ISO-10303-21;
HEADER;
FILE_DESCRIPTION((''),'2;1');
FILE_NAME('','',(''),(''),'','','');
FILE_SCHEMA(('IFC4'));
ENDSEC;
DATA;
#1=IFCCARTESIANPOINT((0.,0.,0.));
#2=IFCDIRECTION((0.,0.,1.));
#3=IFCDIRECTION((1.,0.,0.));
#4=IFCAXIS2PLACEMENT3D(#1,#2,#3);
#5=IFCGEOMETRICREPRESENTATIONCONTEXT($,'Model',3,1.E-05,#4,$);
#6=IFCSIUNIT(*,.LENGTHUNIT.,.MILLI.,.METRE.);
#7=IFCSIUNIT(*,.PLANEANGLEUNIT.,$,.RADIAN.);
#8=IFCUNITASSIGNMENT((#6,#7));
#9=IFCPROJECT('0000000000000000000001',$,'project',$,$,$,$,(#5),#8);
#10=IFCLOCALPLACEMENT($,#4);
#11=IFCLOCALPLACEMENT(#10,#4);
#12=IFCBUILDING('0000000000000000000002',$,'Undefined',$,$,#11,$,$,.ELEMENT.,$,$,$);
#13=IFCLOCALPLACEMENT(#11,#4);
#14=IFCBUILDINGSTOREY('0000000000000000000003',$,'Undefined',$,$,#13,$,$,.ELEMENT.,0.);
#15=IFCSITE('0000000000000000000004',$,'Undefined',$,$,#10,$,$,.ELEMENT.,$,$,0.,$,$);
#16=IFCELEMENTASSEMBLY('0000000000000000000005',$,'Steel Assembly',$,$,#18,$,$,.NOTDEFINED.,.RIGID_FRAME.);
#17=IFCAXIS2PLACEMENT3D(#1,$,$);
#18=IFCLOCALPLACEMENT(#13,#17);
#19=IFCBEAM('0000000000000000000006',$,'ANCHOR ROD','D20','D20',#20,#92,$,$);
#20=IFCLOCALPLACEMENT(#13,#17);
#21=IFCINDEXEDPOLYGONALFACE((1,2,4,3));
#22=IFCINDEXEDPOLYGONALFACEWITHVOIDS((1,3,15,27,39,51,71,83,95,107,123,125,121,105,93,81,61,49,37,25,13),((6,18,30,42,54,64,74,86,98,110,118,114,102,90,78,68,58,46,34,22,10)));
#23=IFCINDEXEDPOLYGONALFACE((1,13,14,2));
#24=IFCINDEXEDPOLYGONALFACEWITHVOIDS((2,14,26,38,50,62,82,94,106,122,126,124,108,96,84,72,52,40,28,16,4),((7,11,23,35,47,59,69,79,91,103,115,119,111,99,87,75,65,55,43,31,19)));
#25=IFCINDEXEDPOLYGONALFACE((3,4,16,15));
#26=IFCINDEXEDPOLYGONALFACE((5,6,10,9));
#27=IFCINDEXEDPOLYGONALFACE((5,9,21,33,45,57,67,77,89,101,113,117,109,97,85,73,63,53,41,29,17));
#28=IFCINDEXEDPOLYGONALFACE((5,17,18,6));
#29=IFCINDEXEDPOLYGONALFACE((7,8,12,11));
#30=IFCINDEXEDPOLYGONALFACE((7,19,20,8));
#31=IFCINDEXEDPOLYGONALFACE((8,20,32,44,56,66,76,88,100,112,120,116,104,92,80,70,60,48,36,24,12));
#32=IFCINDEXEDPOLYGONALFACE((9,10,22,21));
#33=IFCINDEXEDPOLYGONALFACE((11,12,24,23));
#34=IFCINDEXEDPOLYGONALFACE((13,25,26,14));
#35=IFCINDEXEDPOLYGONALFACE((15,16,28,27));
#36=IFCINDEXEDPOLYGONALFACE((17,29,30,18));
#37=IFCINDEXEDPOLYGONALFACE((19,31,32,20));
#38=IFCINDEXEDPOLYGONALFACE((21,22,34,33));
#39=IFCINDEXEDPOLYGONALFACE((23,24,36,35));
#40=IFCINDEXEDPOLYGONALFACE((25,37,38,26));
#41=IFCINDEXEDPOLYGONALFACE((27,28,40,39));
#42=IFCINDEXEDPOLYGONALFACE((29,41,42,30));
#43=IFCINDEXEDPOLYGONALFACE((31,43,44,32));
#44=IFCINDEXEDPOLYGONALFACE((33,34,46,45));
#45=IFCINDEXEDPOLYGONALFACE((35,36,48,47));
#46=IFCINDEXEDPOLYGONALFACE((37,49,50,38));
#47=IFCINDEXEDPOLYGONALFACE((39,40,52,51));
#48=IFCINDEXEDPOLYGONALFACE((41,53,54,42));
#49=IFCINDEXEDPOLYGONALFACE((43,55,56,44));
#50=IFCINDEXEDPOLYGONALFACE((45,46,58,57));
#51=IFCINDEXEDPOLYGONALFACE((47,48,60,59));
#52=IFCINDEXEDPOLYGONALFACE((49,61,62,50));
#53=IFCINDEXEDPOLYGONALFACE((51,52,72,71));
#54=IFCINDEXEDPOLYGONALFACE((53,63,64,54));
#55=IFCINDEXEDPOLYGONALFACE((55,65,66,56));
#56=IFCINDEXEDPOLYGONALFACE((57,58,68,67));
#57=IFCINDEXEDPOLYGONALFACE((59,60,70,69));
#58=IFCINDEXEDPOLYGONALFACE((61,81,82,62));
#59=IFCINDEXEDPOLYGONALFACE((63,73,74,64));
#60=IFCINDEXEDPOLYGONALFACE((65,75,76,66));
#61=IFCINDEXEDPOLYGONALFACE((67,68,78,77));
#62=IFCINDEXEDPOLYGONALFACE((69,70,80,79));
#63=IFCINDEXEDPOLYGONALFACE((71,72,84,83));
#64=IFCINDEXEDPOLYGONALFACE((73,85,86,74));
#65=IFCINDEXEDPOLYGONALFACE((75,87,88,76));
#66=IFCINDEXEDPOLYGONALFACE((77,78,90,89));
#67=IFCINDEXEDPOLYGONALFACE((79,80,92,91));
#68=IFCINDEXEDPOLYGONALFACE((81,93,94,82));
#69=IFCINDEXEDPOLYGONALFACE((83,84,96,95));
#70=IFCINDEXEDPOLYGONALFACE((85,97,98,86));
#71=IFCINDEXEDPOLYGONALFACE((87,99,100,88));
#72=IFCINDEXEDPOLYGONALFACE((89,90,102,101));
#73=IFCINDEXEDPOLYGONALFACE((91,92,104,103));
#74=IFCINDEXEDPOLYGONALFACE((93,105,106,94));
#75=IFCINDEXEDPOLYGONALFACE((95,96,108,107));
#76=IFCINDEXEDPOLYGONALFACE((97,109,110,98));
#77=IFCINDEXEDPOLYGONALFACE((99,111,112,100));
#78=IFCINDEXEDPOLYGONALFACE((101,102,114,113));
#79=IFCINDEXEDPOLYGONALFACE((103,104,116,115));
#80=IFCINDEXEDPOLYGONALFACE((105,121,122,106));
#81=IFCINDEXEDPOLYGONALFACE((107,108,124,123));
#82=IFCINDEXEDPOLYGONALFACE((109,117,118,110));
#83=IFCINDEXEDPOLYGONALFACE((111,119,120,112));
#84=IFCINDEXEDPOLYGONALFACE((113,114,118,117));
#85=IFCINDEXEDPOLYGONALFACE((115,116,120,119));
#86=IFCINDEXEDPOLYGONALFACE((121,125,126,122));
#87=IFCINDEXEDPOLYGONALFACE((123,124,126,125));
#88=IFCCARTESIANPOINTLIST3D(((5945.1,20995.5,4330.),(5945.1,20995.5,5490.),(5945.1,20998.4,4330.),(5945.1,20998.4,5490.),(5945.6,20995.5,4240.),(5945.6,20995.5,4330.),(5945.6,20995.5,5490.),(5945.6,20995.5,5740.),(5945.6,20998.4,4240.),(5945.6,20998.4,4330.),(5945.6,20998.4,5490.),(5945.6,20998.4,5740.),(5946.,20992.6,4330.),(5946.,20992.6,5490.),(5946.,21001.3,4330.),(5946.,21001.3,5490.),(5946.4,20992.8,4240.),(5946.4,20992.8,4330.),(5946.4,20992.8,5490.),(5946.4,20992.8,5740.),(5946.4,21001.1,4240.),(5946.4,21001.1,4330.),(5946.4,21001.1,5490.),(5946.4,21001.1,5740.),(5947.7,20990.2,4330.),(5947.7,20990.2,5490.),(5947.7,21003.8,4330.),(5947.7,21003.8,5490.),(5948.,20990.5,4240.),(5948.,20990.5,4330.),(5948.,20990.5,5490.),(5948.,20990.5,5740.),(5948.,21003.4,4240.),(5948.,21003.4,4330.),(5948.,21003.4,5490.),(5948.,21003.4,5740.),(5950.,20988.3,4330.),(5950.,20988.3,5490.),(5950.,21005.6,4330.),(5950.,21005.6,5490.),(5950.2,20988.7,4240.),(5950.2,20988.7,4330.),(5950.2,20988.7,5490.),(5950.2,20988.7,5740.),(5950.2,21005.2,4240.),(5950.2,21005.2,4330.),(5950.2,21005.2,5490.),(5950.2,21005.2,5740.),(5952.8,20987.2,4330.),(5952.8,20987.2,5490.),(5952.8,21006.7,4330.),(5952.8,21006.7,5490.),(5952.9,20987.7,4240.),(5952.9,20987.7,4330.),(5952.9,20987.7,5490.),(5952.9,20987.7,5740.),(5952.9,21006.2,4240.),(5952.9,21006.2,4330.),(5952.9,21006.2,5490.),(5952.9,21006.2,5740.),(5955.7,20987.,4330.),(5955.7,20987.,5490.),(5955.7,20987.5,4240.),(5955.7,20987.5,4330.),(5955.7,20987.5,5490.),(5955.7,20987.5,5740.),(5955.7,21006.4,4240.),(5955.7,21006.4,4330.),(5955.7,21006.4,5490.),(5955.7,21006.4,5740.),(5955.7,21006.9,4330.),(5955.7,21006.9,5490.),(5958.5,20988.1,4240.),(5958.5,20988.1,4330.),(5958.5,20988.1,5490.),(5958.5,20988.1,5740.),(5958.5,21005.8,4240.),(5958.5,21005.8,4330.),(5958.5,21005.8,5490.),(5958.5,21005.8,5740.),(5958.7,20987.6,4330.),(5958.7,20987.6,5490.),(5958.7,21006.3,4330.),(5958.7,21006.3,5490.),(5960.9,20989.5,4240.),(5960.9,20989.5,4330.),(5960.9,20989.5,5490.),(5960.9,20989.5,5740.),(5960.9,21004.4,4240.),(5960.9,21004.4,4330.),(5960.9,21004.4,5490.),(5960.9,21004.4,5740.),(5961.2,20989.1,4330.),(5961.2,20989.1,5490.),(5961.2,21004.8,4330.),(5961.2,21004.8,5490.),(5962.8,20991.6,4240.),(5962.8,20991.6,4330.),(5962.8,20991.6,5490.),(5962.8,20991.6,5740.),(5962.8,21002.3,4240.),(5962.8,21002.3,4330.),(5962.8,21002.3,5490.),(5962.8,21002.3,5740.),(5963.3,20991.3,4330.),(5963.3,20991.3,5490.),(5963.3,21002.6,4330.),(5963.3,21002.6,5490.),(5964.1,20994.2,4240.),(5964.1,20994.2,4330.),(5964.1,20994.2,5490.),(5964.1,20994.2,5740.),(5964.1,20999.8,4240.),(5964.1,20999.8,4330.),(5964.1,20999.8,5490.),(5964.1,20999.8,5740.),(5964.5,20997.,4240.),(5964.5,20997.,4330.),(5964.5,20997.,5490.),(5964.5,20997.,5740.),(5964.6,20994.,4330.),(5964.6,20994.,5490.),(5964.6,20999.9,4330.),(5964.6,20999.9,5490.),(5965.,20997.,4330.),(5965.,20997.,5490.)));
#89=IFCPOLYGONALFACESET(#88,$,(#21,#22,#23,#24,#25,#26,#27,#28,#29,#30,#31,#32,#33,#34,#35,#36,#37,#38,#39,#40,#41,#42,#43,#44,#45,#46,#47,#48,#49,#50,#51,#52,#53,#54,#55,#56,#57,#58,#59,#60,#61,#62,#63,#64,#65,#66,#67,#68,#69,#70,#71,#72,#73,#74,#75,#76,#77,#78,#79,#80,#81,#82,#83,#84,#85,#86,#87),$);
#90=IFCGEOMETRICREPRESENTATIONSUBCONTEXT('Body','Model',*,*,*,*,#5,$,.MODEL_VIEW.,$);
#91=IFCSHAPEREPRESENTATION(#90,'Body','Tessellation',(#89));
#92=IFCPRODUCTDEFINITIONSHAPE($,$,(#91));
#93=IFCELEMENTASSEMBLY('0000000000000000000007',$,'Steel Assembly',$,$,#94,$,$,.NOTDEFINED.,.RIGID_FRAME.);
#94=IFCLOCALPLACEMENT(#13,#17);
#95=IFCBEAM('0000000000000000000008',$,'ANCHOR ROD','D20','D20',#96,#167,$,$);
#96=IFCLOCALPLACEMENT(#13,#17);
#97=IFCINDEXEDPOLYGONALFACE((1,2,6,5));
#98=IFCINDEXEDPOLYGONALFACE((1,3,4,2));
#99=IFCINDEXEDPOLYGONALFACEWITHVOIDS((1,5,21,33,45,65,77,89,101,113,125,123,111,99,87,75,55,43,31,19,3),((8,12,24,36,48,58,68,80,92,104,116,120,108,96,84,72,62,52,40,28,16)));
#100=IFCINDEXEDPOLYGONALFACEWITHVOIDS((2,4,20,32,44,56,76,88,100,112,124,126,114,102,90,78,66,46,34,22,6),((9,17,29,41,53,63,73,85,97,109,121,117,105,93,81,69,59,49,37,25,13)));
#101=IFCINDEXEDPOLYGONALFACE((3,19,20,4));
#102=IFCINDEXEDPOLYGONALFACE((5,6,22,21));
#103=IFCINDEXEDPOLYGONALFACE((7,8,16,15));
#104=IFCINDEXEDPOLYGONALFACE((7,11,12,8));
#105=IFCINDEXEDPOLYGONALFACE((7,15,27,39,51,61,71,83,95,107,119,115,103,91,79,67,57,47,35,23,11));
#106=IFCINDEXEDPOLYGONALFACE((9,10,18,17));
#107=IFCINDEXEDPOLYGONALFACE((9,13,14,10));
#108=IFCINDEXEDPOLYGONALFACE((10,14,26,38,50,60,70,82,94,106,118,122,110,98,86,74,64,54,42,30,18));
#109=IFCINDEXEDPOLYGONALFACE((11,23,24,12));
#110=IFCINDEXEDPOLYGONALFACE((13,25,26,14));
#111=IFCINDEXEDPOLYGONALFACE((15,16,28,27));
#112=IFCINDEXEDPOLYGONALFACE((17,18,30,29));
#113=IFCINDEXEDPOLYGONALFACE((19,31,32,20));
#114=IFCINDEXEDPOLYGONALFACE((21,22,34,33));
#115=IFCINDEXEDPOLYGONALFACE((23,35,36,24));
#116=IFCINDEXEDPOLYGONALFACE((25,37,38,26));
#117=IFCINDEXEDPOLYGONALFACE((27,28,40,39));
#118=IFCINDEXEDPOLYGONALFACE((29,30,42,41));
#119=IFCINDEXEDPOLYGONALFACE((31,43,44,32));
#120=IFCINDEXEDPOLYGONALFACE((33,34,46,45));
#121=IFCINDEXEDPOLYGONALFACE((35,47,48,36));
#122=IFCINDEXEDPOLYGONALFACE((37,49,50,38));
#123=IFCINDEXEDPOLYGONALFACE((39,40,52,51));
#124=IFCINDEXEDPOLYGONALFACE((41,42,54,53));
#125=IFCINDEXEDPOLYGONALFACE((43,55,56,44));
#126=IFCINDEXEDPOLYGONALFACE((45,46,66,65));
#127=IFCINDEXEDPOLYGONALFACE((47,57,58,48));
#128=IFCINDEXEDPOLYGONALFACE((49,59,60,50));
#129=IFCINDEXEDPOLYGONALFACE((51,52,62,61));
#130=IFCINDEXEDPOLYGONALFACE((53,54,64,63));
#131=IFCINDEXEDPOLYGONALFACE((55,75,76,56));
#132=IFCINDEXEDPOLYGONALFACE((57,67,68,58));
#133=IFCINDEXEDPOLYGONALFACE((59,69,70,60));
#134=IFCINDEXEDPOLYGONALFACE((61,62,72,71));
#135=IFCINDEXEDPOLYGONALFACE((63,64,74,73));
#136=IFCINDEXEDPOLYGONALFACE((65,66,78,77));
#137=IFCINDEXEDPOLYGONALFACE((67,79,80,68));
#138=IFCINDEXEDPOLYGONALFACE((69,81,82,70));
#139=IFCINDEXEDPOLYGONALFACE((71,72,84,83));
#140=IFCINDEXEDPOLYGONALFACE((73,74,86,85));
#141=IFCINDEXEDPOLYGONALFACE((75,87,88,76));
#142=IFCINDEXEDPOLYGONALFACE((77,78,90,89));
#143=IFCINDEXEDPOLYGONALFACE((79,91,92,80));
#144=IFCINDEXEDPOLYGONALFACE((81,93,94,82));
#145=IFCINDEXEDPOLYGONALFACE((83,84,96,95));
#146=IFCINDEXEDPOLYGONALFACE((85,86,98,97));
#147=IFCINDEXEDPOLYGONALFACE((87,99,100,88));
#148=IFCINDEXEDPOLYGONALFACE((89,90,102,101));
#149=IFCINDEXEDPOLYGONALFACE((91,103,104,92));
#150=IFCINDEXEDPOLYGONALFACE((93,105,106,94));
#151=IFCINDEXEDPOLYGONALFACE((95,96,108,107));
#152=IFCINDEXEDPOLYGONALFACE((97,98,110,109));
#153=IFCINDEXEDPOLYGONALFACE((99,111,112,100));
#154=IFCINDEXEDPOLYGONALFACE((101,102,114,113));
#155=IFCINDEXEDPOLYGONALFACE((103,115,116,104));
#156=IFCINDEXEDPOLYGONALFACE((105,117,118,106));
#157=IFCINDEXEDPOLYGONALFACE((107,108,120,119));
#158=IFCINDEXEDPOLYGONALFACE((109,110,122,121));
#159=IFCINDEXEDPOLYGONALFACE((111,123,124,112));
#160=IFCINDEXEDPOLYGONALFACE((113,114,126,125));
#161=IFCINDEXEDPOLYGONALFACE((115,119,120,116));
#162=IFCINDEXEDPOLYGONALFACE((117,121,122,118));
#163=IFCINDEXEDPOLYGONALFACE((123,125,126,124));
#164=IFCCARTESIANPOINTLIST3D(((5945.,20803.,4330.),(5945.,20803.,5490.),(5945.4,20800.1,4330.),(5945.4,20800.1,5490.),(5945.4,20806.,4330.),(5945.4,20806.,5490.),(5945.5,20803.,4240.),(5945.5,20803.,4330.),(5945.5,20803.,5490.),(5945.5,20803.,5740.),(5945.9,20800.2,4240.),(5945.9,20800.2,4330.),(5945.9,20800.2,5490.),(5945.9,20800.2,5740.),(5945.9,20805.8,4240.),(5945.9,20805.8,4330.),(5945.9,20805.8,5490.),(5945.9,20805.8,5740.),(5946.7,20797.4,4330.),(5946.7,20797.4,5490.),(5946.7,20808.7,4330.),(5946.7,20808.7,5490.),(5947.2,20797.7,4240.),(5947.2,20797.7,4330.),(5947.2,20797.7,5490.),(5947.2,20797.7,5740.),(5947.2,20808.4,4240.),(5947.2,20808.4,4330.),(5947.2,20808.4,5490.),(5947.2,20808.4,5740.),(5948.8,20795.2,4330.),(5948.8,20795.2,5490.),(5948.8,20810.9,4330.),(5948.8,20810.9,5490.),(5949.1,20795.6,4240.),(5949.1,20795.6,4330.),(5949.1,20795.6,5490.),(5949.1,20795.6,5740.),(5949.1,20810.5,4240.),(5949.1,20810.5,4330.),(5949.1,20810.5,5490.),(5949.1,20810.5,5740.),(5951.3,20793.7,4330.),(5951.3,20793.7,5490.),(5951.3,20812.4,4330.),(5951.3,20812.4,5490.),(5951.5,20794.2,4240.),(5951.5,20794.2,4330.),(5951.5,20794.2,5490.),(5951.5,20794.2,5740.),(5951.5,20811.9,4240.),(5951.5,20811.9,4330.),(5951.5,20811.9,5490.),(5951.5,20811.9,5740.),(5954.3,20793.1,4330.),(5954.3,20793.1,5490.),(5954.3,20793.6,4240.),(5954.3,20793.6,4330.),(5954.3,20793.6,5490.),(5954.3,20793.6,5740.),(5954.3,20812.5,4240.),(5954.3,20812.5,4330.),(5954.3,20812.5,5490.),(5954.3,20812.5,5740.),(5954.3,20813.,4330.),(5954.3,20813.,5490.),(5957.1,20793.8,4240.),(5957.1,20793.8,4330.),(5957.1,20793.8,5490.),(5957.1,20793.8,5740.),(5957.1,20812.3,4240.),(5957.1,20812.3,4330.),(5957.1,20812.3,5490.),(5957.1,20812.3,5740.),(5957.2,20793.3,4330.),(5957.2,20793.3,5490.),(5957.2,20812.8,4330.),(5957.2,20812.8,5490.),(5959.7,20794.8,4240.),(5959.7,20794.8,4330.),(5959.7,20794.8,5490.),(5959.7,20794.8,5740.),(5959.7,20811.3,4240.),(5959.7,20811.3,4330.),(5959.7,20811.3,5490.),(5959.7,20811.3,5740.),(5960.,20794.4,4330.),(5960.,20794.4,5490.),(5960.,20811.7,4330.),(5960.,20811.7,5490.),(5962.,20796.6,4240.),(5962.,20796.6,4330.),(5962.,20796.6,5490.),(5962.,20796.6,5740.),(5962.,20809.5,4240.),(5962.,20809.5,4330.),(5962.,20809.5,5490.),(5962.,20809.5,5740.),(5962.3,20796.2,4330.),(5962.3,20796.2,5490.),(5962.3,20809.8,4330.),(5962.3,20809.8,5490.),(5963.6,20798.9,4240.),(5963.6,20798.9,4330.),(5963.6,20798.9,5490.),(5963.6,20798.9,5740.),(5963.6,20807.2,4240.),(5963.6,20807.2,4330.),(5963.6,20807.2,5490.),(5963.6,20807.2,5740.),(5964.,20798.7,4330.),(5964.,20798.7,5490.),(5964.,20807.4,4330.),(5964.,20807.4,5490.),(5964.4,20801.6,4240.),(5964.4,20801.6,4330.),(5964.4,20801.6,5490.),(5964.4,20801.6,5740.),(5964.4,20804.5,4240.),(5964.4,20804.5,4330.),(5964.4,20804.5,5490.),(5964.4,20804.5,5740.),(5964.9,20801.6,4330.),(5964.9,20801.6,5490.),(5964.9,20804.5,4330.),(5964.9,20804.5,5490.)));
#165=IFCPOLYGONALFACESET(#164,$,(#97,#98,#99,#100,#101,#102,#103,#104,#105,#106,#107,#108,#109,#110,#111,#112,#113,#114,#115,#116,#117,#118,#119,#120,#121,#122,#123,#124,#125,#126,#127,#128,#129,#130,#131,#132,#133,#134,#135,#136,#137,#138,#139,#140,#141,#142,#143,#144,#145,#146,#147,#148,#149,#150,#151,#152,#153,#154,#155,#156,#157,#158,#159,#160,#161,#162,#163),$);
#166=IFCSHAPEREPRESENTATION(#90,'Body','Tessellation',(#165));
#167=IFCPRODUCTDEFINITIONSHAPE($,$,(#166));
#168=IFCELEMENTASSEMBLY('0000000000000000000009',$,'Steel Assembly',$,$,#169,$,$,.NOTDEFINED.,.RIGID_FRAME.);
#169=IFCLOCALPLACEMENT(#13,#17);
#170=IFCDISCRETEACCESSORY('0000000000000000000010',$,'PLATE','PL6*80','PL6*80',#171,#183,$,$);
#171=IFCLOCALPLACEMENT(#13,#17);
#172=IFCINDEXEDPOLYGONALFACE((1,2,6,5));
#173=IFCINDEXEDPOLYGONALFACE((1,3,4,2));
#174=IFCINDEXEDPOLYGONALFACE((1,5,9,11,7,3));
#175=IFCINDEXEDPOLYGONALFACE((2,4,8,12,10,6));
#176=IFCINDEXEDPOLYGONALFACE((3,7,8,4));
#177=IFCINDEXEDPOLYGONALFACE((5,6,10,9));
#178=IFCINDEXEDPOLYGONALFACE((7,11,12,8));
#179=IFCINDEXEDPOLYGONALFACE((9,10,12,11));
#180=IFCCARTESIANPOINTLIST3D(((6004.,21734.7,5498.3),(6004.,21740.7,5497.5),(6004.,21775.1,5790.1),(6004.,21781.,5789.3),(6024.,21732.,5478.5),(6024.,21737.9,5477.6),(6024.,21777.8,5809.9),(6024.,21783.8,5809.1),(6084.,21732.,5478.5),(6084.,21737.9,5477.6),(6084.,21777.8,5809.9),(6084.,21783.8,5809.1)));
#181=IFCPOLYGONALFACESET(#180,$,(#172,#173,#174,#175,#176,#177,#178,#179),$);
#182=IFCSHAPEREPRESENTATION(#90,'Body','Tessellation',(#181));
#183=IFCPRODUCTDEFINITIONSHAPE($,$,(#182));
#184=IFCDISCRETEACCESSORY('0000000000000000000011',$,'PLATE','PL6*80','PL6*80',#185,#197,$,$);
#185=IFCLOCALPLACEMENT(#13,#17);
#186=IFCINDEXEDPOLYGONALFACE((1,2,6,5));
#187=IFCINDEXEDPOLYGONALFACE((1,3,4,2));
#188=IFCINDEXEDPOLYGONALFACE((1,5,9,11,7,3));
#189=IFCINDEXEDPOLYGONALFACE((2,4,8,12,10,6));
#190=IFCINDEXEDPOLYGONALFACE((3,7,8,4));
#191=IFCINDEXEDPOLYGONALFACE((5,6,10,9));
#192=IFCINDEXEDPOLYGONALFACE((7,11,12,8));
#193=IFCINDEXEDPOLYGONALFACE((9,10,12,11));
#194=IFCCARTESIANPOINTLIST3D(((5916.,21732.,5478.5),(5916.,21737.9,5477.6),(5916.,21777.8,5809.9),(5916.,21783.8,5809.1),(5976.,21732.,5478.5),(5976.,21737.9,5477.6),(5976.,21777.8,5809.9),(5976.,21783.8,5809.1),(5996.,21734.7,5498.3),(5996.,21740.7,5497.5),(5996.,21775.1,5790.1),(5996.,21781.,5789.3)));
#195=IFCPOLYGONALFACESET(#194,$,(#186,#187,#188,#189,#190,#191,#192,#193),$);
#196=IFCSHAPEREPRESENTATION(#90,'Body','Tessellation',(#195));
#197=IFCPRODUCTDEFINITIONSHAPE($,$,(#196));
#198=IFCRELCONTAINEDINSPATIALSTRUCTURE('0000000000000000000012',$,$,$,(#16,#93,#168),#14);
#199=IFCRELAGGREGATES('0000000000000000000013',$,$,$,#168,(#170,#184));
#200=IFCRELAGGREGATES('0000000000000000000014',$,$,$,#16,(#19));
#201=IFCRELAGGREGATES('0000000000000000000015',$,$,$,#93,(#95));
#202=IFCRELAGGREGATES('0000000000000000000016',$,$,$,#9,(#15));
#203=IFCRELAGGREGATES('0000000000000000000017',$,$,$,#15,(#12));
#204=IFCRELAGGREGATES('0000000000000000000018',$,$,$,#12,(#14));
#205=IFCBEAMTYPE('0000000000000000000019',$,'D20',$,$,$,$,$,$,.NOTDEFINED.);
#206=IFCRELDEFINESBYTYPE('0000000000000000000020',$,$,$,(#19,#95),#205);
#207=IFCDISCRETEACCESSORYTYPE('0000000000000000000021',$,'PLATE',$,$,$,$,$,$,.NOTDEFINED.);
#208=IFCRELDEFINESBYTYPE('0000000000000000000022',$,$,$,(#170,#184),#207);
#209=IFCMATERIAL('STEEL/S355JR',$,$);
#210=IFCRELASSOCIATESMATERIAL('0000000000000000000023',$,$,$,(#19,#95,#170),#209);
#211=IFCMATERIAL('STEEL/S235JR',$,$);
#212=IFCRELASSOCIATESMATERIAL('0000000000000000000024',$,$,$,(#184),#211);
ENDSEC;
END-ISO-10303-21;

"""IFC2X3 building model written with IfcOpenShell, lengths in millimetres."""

from ifc_helpers import new_model, si_unit, frame, origin_with_axes, origin_2d_with_axis, place, context, subcontext, project, spatial, polyline, circle, outline, extrude, boolean, material, type_object, element, aggregate, save


model = new_model("IFC2X3")

# Units and contexts
model_context = context("Model", 3, precision=1e-05, world=origin_with_axes())
body_context = subcontext(model_context, "Body", "Model", "MODEL_VIEW")
ifc_project = project(units=[si_unit("LENGTHUNIT", "METRE", prefix="MILLI"), si_unit("PLANEANGLEUNIT", "RADIAN")], contexts=[model_context])

# Site, building, storey
site_placement = place(None, origin_with_axes())
site = spatial("IfcSite", under=ifc_project, at=site_placement, Name="Undefined", CompositionType="ELEMENT", RefElevation=0.0)
building_placement = place(site_placement, origin_with_axes())
building = spatial("IfcBuilding", under=site, at=building_placement, Name="Undefined", CompositionType="ELEMENT")
storey_placement = place(building_placement, origin_with_axes())
storey = spatial("IfcBuildingStorey", under=building, at=storey_placement, Name="Undefined", CompositionType="ELEMENT", Elevation=0.0)

# Shared definitions
ifc_material_1 = material(Name="STEEL/S355JR")
beam_type = type_object("IfcBeamType", Name="D20", PredefinedType="NOTDEFINED")

# Element assemblies, beams
assembly_1_placement = place(storey_placement, origin_with_axes())
assembly_1 = element("IfcElementAssembly", 1, at=assembly_1_placement, inside=storey, Name="Steel Assembly", AssemblyPlace="NOTDEFINED", PredefinedType="RIGID_FRAME")
beam_1_placement = place(assembly_1_placement, frame((5955.0, 20997.0, 5490.0), z_axis=(0.0, 1.0, 0.0), x_axis=(0.0, 0.0, -1.0)))
beam_1 = element("IfcBeam", 2, at=beam_1_placement, type_object=beam_type, material=ifc_material_1, Name="ANCHOR ROD", Description="D20", ObjectType="D20", context=body_context, shape_type="CSG", body=[
    boolean("UNION", boolean("UNION", extrude(circle(Radius=10.0, at=origin_2d_with_axis()), frame((1160.0, 0.0, 0.0), z_axis=(-1.0, 0.0, 0.0), x_axis=(0.0, -1.0, 0.0)), (0.0, 0.0, 1.0), 1160.0), extrude(circle(Radius=9.5, at=origin_2d_with_axis()), frame((1250.0, 0.0, 0.0), z_axis=(-1.0, 0.0, 0.0), x_axis=(0.0, -1.0, 0.0)), (0.0, 0.0, 1.0), 90.0)), extrude(circle(Radius=9.5, at=origin_2d_with_axis()), frame((0.0, 0.0, 0.0), z_axis=(-1.0, 0.0, 0.0), x_axis=(0.0, -1.0, 0.0)), (0.0, 0.0, 1.0), 250.0)),
])
assembly_2_placement = place(storey_placement, origin_with_axes())
assembly_2 = element("IfcElementAssembly", 3, at=assembly_2_placement, inside=storey, Name="Steel Assembly", AssemblyPlace="NOTDEFINED", PredefinedType="RIGID_FRAME")
beam_2_placement = place(assembly_2_placement, frame((5955.0, 20803.0, 5490.0), z_axis=(0.0, -1.0, 0.0), x_axis=(0.0, 0.0, -1.0)))
beam_2 = element("IfcBeam", 4, at=beam_2_placement, type_object=beam_type, material=ifc_material_1, Name="ANCHOR ROD", Description="D20", ObjectType="D20", context=body_context, shape_type="CSG", body=[
    boolean("UNION", boolean("UNION", extrude(circle(Radius=10.0, at=origin_2d_with_axis()), frame((1160.0, 0.0, 0.0), z_axis=(-1.0, 0.0, 0.0), x_axis=(0.0, -1.0, 0.0)), (0.0, 0.0, 1.0), 1160.0), extrude(circle(Radius=9.5, at=origin_2d_with_axis()), frame((1250.0, 0.0, 0.0), z_axis=(-1.0, 0.0, 0.0), x_axis=(0.0, -1.0, 0.0)), (0.0, 0.0, 1.0), 90.0)), extrude(circle(Radius=9.5, at=origin_2d_with_axis()), frame((0.0, 0.0, 0.0), z_axis=(-1.0, 0.0, 0.0), x_axis=(0.0, -1.0, 0.0)), (0.0, 0.0, 1.0), 250.0)),
])

# Element assembly, discrete accessories
assembly_3_placement = place(storey_placement, origin_with_axes())
assembly_3 = element("IfcElementAssembly", 5, at=assembly_3_placement, inside=storey, Name="Steel Assembly", AssemblyPlace="NOTDEFINED", PredefinedType="RIGID_FRAME")
discrete_accessory_type_1 = type_object("IfcDiscreteAccessoryType", Name="PLATE")
discrete_accessory_1_placement = place(assembly_3_placement, frame((6084.0, 21735.0, 5478.1), z_axis=(0.0, 0.990574, -0.13698), x_axis=(-1.0, 0.0, 0.0)))
discrete_accessory_1 = element("IfcDiscreteAccessory", 6, at=discrete_accessory_1_placement, type_object=discrete_accessory_type_1, material=ifc_material_1, Name="PLATE", Description="PL6*80", ObjectType="PL6*80", context=body_context, shape_type="SweptSolid", body=[
    extrude(outline(polyline([(0.0, 0.0), (60.0, 0.0), (80.0, 20.0), (80.0, 314.6), (60.0, 334.6), (0.0, 334.6), (0.0, 0.0)])), frame((0.0, 0.0, -3.0), z_axis=(0.0, 0.0, 1.0), x_axis=(1.0, 0.0, 0.0)), (0.0, 0.0, 1.0), 6.0),
])
ifc_material_2 = material(Name="STEEL/S235JR")
discrete_accessory_2_placement = place(assembly_3_placement, frame((5996.0, 21735.0, 5478.1), z_axis=(0.0, 0.990574, -0.13698), x_axis=(-1.0, 0.0, 0.0)))
discrete_accessory_2 = element("IfcDiscreteAccessory", 7, at=discrete_accessory_2_placement, type_object=discrete_accessory_type_1, material=ifc_material_2, Name="PLATE", Description="PL6*80", ObjectType="PL6*80", context=body_context, shape_type="SweptSolid", body=[
    extrude(outline(polyline([(0.0, 20.0), (20.0, 0.0), (80.0, 0.0), (80.0, 334.6), (20.0, 334.6), (0.0, 314.6), (0.0, 20.0)])), frame((0.0, 0.0, -3.0), z_axis=(0.0, 0.0, 1.0), x_axis=(1.0, 0.0, 0.0)), (0.0, 0.0, 1.0), 6.0),
])
aggregate(assembly_3, [discrete_accessory_1, discrete_accessory_2])

aggregate(assembly_1, [beam_1])
aggregate(assembly_2, [beam_2])

save(model, "model.ifc")
